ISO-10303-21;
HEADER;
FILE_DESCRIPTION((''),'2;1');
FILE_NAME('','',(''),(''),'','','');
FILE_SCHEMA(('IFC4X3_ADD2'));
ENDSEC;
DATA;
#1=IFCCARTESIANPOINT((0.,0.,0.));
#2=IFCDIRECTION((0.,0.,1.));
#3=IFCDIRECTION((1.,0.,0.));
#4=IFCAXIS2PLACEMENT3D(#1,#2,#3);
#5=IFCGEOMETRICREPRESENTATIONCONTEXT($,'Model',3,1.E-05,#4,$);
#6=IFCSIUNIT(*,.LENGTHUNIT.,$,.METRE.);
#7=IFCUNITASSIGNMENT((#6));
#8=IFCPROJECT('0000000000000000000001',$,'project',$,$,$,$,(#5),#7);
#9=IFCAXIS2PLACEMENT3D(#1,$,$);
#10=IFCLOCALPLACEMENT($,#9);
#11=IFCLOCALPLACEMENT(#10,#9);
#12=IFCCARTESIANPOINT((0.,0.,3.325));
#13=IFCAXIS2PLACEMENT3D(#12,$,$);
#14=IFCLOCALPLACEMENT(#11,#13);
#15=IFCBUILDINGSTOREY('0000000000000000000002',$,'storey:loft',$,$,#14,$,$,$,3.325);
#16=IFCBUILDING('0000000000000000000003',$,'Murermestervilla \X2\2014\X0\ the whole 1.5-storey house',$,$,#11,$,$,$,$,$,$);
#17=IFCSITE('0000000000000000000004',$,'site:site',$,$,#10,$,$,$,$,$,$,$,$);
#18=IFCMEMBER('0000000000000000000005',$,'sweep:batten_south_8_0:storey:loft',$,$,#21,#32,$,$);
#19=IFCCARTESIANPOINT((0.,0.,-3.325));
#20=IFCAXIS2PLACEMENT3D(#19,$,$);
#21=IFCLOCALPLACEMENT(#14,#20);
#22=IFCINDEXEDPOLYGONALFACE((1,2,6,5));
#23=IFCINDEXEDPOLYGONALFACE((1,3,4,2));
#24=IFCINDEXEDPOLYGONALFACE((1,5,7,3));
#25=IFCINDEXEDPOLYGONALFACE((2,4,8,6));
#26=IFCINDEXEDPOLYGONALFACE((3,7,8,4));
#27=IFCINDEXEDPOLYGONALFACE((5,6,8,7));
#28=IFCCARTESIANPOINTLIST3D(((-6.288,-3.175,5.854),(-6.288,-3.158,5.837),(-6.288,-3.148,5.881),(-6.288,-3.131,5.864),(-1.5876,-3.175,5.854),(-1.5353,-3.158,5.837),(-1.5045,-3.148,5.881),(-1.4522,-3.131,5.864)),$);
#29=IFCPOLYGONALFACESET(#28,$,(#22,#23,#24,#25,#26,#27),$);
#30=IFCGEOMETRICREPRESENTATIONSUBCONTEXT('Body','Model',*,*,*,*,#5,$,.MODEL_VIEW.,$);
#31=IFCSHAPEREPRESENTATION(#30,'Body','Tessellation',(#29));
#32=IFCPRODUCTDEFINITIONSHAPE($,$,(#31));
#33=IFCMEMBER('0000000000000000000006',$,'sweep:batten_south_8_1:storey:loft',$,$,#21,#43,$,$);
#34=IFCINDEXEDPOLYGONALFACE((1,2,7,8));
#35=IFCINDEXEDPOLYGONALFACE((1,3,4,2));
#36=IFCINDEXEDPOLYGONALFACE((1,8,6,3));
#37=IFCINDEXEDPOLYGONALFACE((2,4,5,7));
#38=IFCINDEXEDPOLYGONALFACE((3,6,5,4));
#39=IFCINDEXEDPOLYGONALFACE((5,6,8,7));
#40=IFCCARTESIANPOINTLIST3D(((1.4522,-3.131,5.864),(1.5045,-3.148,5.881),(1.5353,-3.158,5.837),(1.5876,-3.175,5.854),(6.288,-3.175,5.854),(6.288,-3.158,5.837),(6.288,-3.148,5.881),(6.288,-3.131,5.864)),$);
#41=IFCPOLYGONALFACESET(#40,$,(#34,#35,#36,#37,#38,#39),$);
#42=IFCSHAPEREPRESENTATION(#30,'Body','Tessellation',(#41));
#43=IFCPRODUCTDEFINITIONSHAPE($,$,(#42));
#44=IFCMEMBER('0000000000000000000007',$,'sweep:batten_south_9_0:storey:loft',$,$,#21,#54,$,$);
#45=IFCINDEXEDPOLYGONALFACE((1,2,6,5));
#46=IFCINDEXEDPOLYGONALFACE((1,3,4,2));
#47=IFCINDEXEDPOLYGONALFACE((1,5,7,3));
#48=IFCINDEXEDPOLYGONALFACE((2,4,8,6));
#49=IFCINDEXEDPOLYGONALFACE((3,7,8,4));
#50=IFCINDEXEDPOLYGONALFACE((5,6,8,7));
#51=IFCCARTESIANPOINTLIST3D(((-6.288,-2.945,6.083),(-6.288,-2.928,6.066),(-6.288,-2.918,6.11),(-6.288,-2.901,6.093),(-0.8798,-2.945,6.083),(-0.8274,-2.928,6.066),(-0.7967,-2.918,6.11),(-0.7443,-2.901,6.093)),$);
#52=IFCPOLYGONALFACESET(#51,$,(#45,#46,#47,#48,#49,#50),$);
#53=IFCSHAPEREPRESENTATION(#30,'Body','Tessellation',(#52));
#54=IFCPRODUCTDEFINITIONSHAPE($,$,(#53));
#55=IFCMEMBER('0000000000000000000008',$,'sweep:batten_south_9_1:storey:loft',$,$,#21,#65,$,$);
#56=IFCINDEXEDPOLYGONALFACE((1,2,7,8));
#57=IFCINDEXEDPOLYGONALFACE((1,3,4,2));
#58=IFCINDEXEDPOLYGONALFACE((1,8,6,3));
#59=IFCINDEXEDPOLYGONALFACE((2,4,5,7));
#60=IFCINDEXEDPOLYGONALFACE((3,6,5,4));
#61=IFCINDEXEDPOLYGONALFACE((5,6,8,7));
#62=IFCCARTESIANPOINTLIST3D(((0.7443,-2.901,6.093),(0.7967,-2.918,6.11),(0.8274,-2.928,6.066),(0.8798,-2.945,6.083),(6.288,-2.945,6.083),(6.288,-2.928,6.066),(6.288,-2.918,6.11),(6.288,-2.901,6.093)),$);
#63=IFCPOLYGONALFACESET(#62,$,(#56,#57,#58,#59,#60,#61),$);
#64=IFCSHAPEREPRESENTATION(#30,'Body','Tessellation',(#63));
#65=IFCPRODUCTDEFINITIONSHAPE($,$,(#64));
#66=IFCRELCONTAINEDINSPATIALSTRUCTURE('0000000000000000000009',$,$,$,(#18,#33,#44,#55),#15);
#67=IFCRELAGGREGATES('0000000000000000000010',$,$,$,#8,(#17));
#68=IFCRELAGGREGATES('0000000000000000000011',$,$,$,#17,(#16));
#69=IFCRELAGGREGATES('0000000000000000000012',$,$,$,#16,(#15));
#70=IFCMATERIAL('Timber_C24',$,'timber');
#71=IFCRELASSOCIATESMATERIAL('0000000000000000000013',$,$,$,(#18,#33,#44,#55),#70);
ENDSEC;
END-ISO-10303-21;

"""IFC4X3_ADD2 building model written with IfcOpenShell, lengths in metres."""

from ifc_helpers import new_model, si_unit, frame, origin, origin_with_axes, place, context, subcontext, project, spatial, polyline, outline, extrude, clip, halfspace, material, element, save


model = new_model("IFC4X3_ADD2")

# Units and contexts
model_context = context("Model", 3, precision=1e-05, world=origin_with_axes())
body_context = subcontext(model_context, "Body", "Model", "MODEL_VIEW")
ifc_project = project(units=[si_unit("LENGTHUNIT", "METRE")], contexts=[model_context])

# Site, building, storey
site_placement = place(None, origin())
site = spatial("IfcSite", under=ifc_project, at=site_placement, Name="site:site")
building_placement = place(site_placement, origin())
building = spatial("IfcBuilding", under=site, at=building_placement, Name="Murermestervilla — the whole 1.5-storey house")
storey_placement = place(building_placement, frame((0.0, 0.0, 3.325)))
storey = spatial("IfcBuildingStorey", under=building, at=storey_placement, Name="storey:loft", Elevation=3.325)

# Members
ifc_material = material(Name="Timber_C24", Category="timber")
placement = place(storey_placement, frame((0.0, 0.0, -3.325)))
element("IfcMember", 1, at=placement, inside=storey, material=ifc_material, Name="sweep:batten_south_8_0:storey:loft", context=body_context, shape_type="CSG", body=[
    clip(extrude(outline(polyline([(-0.005, -0.022), (0.022, 0.005), (0.005, 0.022), (-0.022, -0.005), (-0.005, -0.022)])), frame((-6.288, -3.153, 5.859), z_axis=(1.0, 0.0, 0.0), x_axis=(0.0, 1.0, 0.0)), (0.0, 0.0, 1.0), 5.014), halfspace(frame((-1.84, -3.257, 5.596), z_axis=(-0.309017, 0.951057, 0.0), x_axis=(0.951057, 0.309017, 0.0)), True)),
])
element("IfcMember", 2, at=placement, inside=storey, material=ifc_material, Name="sweep:batten_south_8_1:storey:loft", context=body_context, shape_type="CSG", body=[
    clip(extrude(outline(polyline([(-0.005, -0.022), (0.022, 0.005), (0.005, 0.022), (-0.022, -0.005), (-0.005, -0.022)])), frame((1.274, -3.153, 5.859), z_axis=(1.0, 0.0, 0.0), x_axis=(0.0, 1.0, 0.0)), (0.0, 0.0, 1.0), 5.014), halfspace(frame((1.84, -3.257, 5.596), z_axis=(0.309017, 0.951057, 0.0), x_axis=(0.951057, -0.309017, 0.0)), True)),
])
element("IfcMember", 3, at=placement, inside=storey, material=ifc_material, Name="sweep:batten_south_9_0:storey:loft", context=body_context, shape_type="CSG", body=[
    clip(extrude(outline(polyline([(-0.005, -0.022), (0.022, 0.005), (0.005, 0.022), (-0.022, -0.005), (-0.005, -0.022)])), frame((-6.288, -2.923, 6.088), z_axis=(1.0, 0.0, 0.0), x_axis=(0.0, 1.0, 0.0)), (0.0, 0.0, 1.0), 5.72), halfspace(frame((-1.84, -3.257, 5.596), z_axis=(-0.309017, 0.951057, 0.0), x_axis=(0.951057, 0.309017, 0.0)), True)),
])
element("IfcMember", 4, at=placement, inside=storey, material=ifc_material, Name="sweep:batten_south_9_1:storey:loft", context=body_context, shape_type="CSG", body=[
    clip(extrude(outline(polyline([(-0.005, -0.022), (0.022, 0.005), (0.005, 0.022), (-0.022, -0.005), (-0.005, -0.022)])), frame((0.568, -2.923, 6.088), z_axis=(1.0, 0.0, 0.0), x_axis=(0.0, 1.0, 0.0)), (0.0, 0.0, 1.0), 5.72), halfspace(frame((1.84, -3.257, 5.596), z_axis=(0.309017, 0.951057, 0.0), x_axis=(0.951057, -0.309017, 0.0)), True)),
])

save(model, "model.ifc")
